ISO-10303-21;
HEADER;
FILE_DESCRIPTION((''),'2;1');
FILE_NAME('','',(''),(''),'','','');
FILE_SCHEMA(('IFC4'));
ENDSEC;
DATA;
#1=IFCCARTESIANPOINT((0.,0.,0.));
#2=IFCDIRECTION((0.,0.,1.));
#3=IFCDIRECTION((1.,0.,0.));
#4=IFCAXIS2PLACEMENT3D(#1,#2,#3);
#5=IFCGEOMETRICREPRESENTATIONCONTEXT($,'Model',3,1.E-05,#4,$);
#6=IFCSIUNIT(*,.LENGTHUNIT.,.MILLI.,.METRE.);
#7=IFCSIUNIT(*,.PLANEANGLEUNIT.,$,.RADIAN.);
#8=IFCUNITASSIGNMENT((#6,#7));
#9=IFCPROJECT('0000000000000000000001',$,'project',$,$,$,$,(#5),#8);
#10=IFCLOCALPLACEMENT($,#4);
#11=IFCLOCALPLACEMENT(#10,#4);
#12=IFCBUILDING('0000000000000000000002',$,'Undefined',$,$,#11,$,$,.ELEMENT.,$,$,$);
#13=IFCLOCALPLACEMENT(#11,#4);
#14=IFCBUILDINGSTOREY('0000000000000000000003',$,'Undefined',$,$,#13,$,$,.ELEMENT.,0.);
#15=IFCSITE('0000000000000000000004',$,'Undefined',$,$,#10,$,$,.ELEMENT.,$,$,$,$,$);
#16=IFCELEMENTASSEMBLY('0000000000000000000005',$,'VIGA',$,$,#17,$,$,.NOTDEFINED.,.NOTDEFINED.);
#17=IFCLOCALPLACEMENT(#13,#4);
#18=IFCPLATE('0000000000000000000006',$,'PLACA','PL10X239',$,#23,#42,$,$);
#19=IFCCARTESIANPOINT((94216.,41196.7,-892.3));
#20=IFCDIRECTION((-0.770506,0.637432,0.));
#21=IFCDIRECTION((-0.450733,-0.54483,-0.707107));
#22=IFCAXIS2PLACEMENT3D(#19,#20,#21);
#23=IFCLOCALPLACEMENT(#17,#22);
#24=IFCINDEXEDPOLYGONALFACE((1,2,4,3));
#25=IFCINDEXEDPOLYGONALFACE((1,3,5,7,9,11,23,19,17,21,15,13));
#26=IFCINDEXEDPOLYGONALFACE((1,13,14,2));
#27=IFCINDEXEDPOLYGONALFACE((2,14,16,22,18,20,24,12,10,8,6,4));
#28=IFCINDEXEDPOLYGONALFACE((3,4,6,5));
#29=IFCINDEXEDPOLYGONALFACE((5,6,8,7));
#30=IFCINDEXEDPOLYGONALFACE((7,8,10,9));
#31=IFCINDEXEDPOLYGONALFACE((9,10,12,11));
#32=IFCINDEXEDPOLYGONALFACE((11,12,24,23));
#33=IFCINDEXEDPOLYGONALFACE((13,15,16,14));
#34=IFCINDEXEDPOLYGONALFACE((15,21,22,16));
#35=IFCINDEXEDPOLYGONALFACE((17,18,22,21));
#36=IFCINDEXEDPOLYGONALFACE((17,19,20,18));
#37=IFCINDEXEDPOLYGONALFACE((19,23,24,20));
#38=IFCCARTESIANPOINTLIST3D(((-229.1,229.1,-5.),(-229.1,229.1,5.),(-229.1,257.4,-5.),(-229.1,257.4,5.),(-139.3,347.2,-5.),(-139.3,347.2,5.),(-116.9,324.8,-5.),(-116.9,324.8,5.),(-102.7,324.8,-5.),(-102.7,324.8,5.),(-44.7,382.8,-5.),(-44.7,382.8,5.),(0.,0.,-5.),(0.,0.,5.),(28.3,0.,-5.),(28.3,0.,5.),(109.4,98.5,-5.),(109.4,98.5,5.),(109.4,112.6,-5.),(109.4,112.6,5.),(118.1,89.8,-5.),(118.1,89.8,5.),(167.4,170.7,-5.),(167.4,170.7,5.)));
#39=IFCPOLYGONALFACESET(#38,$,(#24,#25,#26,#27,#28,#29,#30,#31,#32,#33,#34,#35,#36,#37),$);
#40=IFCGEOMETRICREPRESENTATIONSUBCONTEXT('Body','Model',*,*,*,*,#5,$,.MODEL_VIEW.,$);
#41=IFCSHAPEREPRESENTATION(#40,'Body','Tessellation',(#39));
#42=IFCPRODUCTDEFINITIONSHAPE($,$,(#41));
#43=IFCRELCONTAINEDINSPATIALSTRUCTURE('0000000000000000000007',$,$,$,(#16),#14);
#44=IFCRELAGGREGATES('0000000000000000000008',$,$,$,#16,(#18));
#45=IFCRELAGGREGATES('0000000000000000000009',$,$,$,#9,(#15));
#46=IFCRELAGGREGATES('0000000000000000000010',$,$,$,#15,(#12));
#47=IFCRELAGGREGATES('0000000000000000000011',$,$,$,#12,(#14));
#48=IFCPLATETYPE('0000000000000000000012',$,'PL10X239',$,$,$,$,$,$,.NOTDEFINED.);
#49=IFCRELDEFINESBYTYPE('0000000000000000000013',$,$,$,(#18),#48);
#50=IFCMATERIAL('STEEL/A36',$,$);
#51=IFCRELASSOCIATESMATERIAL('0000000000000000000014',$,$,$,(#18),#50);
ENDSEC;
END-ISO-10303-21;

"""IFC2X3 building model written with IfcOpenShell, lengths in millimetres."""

from ifc_helpers import new_model, si_unit, frame, origin_with_axes, place, context, subcontext, project, spatial, polyline, outline, extrude, material, type_object, element, aggregate, save


model = new_model("IFC2X3")

# Units and contexts
model_context = context("Model", 3, precision=1e-05, world=origin_with_axes())
body_context = subcontext(model_context, "Body", "Model", "MODEL_VIEW")
ifc_project = project(units=[si_unit("LENGTHUNIT", "METRE", prefix="MILLI"), si_unit("PLANEANGLEUNIT", "RADIAN")], contexts=[model_context])

# Site, building, storey
site_placement = place(None, origin_with_axes())
site = spatial("IfcSite", under=ifc_project, at=site_placement, Name="Undefined", CompositionType="ELEMENT")
building_placement = place(site_placement, origin_with_axes())
building = spatial("IfcBuilding", under=site, at=building_placement, Name="Undefined", CompositionType="ELEMENT")
storey_placement = place(building_placement, origin_with_axes())
storey = spatial("IfcBuildingStorey", under=building, at=storey_placement, Name="Undefined", CompositionType="ELEMENT", Elevation=0.0)

# Shared definitions
ifc_material_1 = material(Name="STEEL/A36")

# Element assembly
assembly_1_placement = place(storey_placement, origin_with_axes())
assembly_1 = element("IfcElementAssembly", 1, at=assembly_1_placement, inside=storey, Name="VIGA", AssemblyPlace="NOTDEFINED", PredefinedType="NOTDEFINED")

# Plate
plate_type_1 = type_object("IfcPlateType", Name="PL10X239", PredefinedType="NOTDEFINED")
plate_1_placement = place(assembly_1_placement, frame((94216.0, 41196.7, -892.3), z_axis=(-0.770506, 0.637432, 0.0), x_axis=(-0.450733, -0.54483, -0.707107)))
plate_1 = element("IfcPlate", 2, at=plate_1_placement, type_object=plate_type_1, material=ifc_material_1, Name="PLACA", Description="PL10X239", context=body_context, shape_type="SweptSolid", body=[
    extrude(outline(polyline([(0.0, 0.0), (28.3, 0.0), (118.1, 89.8), (109.4, 98.5), (109.4, 112.6), (167.4, 170.7), (-44.7, 382.8), (-102.7, 324.8), (-116.9, 324.8), (-139.3, 347.2), (-229.1, 257.4), (-229.1, 229.1), (0.0, 0.0)])), frame((0.0, 0.0, -5.0), z_axis=(0.0, 0.0, 1.0), x_axis=(1.0, 0.0, 0.0)), (0.0, 0.0, 1.0), 10.0),
])

aggregate(assembly_1, [plate_1])

save(model, "model.ifc")
